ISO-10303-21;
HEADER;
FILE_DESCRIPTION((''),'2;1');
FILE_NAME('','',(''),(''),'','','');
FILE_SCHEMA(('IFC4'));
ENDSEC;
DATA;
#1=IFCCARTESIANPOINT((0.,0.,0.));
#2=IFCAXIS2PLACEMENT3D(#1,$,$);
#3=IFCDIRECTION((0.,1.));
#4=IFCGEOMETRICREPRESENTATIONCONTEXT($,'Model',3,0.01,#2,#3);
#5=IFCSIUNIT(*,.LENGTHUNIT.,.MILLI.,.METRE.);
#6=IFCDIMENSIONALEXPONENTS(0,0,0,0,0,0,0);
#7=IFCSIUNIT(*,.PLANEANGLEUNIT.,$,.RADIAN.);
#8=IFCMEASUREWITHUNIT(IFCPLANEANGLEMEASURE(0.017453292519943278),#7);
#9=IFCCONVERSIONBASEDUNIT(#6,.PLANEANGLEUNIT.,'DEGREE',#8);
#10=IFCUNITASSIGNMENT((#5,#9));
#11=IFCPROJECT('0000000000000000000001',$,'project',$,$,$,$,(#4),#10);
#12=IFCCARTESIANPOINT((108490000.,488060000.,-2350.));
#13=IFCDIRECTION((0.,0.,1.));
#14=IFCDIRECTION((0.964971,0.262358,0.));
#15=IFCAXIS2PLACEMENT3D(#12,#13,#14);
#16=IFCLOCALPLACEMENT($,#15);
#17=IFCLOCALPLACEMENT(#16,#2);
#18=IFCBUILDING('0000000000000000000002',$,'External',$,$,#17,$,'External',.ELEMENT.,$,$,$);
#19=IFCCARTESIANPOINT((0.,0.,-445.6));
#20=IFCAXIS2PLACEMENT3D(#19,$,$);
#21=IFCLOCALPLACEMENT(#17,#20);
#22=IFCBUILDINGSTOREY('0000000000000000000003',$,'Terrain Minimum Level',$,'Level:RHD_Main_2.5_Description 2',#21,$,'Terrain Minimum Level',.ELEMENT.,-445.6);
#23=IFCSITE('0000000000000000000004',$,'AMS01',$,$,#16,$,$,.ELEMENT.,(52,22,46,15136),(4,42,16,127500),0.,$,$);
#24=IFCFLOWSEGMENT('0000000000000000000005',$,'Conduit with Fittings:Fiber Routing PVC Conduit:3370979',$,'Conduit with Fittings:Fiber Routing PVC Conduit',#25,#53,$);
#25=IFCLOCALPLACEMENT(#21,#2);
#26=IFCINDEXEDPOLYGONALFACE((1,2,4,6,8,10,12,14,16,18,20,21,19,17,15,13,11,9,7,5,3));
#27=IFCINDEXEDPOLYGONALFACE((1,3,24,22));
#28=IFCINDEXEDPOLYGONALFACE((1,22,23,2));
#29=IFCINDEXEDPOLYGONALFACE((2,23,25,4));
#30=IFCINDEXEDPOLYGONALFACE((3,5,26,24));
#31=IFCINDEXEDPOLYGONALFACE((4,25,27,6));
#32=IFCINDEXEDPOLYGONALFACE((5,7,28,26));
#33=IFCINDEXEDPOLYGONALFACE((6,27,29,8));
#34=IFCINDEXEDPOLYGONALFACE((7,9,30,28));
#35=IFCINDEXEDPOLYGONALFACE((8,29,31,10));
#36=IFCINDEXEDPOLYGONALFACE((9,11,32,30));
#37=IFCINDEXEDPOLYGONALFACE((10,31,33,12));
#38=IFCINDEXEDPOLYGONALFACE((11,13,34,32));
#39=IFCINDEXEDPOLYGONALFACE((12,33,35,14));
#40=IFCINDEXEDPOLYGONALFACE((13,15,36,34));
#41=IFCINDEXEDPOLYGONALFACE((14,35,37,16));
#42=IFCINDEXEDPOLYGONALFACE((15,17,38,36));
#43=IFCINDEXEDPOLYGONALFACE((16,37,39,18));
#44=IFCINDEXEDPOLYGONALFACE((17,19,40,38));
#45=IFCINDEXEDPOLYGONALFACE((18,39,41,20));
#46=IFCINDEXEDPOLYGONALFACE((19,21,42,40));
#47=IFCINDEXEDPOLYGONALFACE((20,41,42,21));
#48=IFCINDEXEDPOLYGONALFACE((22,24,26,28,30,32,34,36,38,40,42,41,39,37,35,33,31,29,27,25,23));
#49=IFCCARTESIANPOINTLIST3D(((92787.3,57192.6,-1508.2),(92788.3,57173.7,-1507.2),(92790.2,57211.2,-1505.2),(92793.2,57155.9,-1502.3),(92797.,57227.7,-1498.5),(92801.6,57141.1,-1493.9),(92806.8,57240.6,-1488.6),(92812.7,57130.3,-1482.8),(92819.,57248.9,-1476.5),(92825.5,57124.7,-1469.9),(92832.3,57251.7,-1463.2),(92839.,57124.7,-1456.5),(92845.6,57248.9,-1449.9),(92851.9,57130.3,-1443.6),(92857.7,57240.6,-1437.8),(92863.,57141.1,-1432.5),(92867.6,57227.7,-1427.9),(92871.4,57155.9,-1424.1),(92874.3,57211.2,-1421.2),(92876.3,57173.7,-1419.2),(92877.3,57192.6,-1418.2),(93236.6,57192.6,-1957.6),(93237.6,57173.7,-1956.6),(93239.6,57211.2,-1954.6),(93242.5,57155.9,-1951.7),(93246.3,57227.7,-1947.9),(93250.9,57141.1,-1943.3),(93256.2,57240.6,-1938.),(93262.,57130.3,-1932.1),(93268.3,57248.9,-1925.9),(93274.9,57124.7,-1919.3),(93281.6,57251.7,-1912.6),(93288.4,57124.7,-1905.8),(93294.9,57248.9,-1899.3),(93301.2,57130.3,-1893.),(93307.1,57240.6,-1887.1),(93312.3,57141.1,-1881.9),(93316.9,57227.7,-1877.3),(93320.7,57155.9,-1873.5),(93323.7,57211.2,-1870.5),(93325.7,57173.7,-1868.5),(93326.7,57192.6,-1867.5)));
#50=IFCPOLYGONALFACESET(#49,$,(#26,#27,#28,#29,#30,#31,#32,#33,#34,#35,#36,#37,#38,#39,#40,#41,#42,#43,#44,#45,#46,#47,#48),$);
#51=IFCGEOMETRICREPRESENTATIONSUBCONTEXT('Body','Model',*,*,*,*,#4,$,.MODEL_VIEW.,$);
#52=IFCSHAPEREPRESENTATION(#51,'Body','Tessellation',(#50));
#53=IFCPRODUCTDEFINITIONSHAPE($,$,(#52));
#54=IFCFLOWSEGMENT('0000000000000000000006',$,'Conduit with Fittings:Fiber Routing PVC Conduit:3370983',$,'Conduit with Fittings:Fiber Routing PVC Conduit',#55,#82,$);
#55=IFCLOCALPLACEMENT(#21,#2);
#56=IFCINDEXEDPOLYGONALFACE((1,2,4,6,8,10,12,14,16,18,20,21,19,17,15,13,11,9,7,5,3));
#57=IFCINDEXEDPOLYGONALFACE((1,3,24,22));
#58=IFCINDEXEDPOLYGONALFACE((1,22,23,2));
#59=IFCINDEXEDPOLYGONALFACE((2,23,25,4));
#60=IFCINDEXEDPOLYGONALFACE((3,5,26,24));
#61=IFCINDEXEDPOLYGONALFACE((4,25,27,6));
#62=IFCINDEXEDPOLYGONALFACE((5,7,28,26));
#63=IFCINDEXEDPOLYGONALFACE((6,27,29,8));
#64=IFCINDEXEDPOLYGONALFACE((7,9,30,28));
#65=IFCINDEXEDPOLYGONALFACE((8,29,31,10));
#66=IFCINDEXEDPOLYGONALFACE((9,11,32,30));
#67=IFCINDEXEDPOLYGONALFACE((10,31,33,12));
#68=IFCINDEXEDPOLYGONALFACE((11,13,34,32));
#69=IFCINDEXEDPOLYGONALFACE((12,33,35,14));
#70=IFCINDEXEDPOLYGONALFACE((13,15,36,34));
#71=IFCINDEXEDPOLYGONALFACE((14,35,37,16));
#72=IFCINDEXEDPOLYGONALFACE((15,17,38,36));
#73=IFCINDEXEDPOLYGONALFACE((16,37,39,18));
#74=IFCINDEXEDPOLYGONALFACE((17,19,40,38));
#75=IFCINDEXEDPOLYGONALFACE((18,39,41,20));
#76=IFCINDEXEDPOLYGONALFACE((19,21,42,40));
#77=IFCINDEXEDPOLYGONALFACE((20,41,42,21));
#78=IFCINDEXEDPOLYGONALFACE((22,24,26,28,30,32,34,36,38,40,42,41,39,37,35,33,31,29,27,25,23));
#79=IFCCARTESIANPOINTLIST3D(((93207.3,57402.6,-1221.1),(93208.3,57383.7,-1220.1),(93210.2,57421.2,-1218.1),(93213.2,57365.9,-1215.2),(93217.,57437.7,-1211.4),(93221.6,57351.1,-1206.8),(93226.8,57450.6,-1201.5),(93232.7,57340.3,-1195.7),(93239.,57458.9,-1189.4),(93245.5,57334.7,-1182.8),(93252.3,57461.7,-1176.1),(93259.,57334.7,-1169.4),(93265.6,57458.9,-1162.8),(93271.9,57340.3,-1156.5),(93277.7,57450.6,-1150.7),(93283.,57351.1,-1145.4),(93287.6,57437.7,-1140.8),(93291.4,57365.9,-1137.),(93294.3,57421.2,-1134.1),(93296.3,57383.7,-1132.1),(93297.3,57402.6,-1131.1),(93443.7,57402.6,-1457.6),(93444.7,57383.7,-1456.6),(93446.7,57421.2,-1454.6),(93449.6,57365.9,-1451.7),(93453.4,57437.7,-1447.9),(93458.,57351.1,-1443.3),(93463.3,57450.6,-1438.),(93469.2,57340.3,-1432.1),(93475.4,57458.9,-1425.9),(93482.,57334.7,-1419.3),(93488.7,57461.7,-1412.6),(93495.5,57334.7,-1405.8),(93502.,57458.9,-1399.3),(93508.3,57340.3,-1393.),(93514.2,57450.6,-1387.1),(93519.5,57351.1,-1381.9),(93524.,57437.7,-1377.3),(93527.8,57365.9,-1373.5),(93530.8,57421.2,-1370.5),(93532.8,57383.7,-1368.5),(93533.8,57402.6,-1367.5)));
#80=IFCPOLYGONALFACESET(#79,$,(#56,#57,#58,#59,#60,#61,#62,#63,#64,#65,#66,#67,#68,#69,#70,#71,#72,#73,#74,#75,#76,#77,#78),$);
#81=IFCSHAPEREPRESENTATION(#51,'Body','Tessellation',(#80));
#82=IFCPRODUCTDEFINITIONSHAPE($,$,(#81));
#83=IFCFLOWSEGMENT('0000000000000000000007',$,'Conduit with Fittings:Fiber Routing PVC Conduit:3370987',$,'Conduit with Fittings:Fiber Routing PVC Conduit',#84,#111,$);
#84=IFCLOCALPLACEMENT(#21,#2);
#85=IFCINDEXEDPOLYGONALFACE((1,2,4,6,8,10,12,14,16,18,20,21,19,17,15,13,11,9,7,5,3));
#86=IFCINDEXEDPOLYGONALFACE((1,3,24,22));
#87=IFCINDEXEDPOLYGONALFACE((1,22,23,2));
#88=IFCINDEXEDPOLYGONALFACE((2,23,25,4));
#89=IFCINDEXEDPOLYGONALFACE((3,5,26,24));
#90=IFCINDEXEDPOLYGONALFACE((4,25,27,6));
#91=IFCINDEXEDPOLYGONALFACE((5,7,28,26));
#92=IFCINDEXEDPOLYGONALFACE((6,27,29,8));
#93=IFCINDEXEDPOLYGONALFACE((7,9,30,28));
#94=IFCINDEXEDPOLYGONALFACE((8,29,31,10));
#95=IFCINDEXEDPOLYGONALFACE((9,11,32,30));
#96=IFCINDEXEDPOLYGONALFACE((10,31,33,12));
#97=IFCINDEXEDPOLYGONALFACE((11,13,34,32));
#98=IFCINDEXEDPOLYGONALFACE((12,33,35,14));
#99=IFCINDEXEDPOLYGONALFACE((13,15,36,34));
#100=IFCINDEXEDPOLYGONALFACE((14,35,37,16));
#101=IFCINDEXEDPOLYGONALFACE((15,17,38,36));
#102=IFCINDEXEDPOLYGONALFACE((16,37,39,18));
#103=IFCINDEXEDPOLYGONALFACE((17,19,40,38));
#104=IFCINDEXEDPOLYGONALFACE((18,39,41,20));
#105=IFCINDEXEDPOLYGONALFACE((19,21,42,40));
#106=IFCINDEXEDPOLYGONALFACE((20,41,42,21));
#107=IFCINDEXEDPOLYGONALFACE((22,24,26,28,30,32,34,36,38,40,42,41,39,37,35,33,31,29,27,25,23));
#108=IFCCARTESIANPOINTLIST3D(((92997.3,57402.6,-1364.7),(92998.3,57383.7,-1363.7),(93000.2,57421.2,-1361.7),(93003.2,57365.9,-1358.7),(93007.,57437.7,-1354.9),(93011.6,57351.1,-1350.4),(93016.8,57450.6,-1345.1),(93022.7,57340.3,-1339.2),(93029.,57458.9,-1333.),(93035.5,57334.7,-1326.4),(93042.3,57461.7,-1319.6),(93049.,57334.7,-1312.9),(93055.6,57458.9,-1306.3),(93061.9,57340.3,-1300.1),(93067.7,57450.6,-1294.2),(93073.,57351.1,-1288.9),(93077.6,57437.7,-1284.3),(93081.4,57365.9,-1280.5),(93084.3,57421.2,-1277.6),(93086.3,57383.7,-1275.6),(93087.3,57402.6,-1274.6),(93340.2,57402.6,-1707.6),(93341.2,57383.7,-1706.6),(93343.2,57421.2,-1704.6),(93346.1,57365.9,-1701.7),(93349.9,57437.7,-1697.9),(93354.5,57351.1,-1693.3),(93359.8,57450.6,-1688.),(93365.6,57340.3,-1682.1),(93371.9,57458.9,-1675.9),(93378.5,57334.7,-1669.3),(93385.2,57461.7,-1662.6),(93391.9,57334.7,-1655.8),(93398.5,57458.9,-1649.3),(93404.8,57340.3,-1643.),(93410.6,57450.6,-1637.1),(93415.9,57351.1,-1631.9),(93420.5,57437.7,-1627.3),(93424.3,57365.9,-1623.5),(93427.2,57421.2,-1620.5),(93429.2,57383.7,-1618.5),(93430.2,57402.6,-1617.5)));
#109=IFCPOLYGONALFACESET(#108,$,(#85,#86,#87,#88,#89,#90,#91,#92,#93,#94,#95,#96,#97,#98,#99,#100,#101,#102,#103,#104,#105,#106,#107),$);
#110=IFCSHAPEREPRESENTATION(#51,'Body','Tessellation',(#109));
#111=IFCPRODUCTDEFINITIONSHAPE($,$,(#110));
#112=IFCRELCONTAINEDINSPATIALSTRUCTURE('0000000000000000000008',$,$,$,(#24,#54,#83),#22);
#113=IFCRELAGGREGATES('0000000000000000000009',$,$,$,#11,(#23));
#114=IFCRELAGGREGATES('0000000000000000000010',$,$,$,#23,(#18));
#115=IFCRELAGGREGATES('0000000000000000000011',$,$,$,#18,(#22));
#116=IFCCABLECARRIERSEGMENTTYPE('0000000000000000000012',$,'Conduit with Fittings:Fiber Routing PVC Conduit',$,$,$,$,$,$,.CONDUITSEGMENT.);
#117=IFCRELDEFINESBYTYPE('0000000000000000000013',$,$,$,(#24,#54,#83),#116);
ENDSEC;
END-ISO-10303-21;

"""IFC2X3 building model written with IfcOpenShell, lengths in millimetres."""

from ifc_helpers import new_model, entity, si_unit, converted_unit, direction, frame, frame_2d, origin, origin_2d_with_axis, place, context, subcontext, project, spatial, circle, extrude, type_object, element, save


model = new_model("IFC2X3")

# Units and contexts
model_context = context("Model", 3, precision=0.01, world=origin(), true_north=direction((0.0, 1.0)))
body_context = subcontext(model_context, "Body", "Model", "MODEL_VIEW")
ifc_project = project(units=[si_unit("LENGTHUNIT", "METRE", prefix="MILLI"), converted_unit("PLANEANGLEUNIT", "DEGREE", entity("IfcPlaneAngleMeasure", 0.017453292519943278), si_unit("PLANEANGLEUNIT", "RADIAN"), dimensions=[0, 0, 0, 0, 0, 0, 0])], contexts=[model_context])

# Site, building, storey
site_placement = place(None, frame((108490000.0, 488060000.0, -2350.0), z_axis=(0.0, 0.0, 1.0), x_axis=(0.964971, 0.262358, 0.0)))
site = spatial("IfcSite", under=ifc_project, at=site_placement, Name="AMS01", CompositionType="ELEMENT", RefLatitude=(52, 22, 46, 15136), RefLongitude=(4, 42, 16, 127500), RefElevation=0.0)
building_placement = place(site_placement, origin())
building = spatial("IfcBuilding", under=site, at=building_placement, Name="External", LongName="External", CompositionType="ELEMENT")
storey_placement = place(building_placement, frame((0.0, 0.0, -445.6)))
storey = spatial("IfcBuildingStorey", under=building, at=storey_placement, Name="Terrain Minimum Level", ObjectType="Level:RHD_Main_2.5_Description 2", LongName="Terrain Minimum Level", CompositionType="ELEMENT", Elevation=-445.6)

# Flow segments
cable_carrier_segment_type = type_object("IfcCableCarrierSegmentType", Name="Conduit with Fittings:Fiber Routing PVC Conduit", PredefinedType="CONDUITSEGMENT")
flow_segment_1_placement = place(storey_placement, origin())
element("IfcFlowSegment", 1, at=flow_segment_1_placement, inside=storey, type_object=cable_carrier_segment_type, Name="Conduit with Fittings:Fiber Routing PVC Conduit:3370979", ObjectType="Conduit with Fittings:Fiber Routing PVC Conduit", context=body_context, shape_type="SweptSolid", body=[
    extrude(circle(Radius=63.9, at=frame_2d((0.0, 0.0), x_axis=(1.0, 0.0))), frame((93281.6, 57187.9, -1912.6), z_axis=(-0.707107, 0.0, 0.707107), x_axis=(0.0, 1.0, 0.0)), (0.0, 0.0, 1.0), 635.5),
])
flow_segment_2_placement = place(storey_placement, origin())
element("IfcFlowSegment", 2, at=flow_segment_2_placement, inside=storey, type_object=cable_carrier_segment_type, Name="Conduit with Fittings:Fiber Routing PVC Conduit:3370983", ObjectType="Conduit with Fittings:Fiber Routing PVC Conduit", context=body_context, shape_type="SweptSolid", body=[
    extrude(circle(Radius=63.9, at=origin_2d_with_axis()), frame((93252.3, 57397.9, -1176.1), z_axis=(0.707107, 0.0, -0.707107), x_axis=(0.0, 1.0, 0.0)), (0.0, 0.0, 1.0), 334.4),
])
flow_segment_3_placement = place(storey_placement, origin())
element("IfcFlowSegment", 3, at=flow_segment_3_placement, inside=storey, type_object=cable_carrier_segment_type, Name="Conduit with Fittings:Fiber Routing PVC Conduit:3370987", ObjectType="Conduit with Fittings:Fiber Routing PVC Conduit", context=body_context, shape_type="SweptSolid", body=[
    extrude(circle(Radius=63.9, at=frame_2d((0.0, 0.0), x_axis=(1.0, 0.0))), frame((93042.3, 57397.9, -1319.6), z_axis=(0.707107, 0.0, -0.707107), x_axis=(0.0, 1.0, 0.0)), (0.0, 0.0, 1.0), 485.0),
])

save(model, "model.ifc")
